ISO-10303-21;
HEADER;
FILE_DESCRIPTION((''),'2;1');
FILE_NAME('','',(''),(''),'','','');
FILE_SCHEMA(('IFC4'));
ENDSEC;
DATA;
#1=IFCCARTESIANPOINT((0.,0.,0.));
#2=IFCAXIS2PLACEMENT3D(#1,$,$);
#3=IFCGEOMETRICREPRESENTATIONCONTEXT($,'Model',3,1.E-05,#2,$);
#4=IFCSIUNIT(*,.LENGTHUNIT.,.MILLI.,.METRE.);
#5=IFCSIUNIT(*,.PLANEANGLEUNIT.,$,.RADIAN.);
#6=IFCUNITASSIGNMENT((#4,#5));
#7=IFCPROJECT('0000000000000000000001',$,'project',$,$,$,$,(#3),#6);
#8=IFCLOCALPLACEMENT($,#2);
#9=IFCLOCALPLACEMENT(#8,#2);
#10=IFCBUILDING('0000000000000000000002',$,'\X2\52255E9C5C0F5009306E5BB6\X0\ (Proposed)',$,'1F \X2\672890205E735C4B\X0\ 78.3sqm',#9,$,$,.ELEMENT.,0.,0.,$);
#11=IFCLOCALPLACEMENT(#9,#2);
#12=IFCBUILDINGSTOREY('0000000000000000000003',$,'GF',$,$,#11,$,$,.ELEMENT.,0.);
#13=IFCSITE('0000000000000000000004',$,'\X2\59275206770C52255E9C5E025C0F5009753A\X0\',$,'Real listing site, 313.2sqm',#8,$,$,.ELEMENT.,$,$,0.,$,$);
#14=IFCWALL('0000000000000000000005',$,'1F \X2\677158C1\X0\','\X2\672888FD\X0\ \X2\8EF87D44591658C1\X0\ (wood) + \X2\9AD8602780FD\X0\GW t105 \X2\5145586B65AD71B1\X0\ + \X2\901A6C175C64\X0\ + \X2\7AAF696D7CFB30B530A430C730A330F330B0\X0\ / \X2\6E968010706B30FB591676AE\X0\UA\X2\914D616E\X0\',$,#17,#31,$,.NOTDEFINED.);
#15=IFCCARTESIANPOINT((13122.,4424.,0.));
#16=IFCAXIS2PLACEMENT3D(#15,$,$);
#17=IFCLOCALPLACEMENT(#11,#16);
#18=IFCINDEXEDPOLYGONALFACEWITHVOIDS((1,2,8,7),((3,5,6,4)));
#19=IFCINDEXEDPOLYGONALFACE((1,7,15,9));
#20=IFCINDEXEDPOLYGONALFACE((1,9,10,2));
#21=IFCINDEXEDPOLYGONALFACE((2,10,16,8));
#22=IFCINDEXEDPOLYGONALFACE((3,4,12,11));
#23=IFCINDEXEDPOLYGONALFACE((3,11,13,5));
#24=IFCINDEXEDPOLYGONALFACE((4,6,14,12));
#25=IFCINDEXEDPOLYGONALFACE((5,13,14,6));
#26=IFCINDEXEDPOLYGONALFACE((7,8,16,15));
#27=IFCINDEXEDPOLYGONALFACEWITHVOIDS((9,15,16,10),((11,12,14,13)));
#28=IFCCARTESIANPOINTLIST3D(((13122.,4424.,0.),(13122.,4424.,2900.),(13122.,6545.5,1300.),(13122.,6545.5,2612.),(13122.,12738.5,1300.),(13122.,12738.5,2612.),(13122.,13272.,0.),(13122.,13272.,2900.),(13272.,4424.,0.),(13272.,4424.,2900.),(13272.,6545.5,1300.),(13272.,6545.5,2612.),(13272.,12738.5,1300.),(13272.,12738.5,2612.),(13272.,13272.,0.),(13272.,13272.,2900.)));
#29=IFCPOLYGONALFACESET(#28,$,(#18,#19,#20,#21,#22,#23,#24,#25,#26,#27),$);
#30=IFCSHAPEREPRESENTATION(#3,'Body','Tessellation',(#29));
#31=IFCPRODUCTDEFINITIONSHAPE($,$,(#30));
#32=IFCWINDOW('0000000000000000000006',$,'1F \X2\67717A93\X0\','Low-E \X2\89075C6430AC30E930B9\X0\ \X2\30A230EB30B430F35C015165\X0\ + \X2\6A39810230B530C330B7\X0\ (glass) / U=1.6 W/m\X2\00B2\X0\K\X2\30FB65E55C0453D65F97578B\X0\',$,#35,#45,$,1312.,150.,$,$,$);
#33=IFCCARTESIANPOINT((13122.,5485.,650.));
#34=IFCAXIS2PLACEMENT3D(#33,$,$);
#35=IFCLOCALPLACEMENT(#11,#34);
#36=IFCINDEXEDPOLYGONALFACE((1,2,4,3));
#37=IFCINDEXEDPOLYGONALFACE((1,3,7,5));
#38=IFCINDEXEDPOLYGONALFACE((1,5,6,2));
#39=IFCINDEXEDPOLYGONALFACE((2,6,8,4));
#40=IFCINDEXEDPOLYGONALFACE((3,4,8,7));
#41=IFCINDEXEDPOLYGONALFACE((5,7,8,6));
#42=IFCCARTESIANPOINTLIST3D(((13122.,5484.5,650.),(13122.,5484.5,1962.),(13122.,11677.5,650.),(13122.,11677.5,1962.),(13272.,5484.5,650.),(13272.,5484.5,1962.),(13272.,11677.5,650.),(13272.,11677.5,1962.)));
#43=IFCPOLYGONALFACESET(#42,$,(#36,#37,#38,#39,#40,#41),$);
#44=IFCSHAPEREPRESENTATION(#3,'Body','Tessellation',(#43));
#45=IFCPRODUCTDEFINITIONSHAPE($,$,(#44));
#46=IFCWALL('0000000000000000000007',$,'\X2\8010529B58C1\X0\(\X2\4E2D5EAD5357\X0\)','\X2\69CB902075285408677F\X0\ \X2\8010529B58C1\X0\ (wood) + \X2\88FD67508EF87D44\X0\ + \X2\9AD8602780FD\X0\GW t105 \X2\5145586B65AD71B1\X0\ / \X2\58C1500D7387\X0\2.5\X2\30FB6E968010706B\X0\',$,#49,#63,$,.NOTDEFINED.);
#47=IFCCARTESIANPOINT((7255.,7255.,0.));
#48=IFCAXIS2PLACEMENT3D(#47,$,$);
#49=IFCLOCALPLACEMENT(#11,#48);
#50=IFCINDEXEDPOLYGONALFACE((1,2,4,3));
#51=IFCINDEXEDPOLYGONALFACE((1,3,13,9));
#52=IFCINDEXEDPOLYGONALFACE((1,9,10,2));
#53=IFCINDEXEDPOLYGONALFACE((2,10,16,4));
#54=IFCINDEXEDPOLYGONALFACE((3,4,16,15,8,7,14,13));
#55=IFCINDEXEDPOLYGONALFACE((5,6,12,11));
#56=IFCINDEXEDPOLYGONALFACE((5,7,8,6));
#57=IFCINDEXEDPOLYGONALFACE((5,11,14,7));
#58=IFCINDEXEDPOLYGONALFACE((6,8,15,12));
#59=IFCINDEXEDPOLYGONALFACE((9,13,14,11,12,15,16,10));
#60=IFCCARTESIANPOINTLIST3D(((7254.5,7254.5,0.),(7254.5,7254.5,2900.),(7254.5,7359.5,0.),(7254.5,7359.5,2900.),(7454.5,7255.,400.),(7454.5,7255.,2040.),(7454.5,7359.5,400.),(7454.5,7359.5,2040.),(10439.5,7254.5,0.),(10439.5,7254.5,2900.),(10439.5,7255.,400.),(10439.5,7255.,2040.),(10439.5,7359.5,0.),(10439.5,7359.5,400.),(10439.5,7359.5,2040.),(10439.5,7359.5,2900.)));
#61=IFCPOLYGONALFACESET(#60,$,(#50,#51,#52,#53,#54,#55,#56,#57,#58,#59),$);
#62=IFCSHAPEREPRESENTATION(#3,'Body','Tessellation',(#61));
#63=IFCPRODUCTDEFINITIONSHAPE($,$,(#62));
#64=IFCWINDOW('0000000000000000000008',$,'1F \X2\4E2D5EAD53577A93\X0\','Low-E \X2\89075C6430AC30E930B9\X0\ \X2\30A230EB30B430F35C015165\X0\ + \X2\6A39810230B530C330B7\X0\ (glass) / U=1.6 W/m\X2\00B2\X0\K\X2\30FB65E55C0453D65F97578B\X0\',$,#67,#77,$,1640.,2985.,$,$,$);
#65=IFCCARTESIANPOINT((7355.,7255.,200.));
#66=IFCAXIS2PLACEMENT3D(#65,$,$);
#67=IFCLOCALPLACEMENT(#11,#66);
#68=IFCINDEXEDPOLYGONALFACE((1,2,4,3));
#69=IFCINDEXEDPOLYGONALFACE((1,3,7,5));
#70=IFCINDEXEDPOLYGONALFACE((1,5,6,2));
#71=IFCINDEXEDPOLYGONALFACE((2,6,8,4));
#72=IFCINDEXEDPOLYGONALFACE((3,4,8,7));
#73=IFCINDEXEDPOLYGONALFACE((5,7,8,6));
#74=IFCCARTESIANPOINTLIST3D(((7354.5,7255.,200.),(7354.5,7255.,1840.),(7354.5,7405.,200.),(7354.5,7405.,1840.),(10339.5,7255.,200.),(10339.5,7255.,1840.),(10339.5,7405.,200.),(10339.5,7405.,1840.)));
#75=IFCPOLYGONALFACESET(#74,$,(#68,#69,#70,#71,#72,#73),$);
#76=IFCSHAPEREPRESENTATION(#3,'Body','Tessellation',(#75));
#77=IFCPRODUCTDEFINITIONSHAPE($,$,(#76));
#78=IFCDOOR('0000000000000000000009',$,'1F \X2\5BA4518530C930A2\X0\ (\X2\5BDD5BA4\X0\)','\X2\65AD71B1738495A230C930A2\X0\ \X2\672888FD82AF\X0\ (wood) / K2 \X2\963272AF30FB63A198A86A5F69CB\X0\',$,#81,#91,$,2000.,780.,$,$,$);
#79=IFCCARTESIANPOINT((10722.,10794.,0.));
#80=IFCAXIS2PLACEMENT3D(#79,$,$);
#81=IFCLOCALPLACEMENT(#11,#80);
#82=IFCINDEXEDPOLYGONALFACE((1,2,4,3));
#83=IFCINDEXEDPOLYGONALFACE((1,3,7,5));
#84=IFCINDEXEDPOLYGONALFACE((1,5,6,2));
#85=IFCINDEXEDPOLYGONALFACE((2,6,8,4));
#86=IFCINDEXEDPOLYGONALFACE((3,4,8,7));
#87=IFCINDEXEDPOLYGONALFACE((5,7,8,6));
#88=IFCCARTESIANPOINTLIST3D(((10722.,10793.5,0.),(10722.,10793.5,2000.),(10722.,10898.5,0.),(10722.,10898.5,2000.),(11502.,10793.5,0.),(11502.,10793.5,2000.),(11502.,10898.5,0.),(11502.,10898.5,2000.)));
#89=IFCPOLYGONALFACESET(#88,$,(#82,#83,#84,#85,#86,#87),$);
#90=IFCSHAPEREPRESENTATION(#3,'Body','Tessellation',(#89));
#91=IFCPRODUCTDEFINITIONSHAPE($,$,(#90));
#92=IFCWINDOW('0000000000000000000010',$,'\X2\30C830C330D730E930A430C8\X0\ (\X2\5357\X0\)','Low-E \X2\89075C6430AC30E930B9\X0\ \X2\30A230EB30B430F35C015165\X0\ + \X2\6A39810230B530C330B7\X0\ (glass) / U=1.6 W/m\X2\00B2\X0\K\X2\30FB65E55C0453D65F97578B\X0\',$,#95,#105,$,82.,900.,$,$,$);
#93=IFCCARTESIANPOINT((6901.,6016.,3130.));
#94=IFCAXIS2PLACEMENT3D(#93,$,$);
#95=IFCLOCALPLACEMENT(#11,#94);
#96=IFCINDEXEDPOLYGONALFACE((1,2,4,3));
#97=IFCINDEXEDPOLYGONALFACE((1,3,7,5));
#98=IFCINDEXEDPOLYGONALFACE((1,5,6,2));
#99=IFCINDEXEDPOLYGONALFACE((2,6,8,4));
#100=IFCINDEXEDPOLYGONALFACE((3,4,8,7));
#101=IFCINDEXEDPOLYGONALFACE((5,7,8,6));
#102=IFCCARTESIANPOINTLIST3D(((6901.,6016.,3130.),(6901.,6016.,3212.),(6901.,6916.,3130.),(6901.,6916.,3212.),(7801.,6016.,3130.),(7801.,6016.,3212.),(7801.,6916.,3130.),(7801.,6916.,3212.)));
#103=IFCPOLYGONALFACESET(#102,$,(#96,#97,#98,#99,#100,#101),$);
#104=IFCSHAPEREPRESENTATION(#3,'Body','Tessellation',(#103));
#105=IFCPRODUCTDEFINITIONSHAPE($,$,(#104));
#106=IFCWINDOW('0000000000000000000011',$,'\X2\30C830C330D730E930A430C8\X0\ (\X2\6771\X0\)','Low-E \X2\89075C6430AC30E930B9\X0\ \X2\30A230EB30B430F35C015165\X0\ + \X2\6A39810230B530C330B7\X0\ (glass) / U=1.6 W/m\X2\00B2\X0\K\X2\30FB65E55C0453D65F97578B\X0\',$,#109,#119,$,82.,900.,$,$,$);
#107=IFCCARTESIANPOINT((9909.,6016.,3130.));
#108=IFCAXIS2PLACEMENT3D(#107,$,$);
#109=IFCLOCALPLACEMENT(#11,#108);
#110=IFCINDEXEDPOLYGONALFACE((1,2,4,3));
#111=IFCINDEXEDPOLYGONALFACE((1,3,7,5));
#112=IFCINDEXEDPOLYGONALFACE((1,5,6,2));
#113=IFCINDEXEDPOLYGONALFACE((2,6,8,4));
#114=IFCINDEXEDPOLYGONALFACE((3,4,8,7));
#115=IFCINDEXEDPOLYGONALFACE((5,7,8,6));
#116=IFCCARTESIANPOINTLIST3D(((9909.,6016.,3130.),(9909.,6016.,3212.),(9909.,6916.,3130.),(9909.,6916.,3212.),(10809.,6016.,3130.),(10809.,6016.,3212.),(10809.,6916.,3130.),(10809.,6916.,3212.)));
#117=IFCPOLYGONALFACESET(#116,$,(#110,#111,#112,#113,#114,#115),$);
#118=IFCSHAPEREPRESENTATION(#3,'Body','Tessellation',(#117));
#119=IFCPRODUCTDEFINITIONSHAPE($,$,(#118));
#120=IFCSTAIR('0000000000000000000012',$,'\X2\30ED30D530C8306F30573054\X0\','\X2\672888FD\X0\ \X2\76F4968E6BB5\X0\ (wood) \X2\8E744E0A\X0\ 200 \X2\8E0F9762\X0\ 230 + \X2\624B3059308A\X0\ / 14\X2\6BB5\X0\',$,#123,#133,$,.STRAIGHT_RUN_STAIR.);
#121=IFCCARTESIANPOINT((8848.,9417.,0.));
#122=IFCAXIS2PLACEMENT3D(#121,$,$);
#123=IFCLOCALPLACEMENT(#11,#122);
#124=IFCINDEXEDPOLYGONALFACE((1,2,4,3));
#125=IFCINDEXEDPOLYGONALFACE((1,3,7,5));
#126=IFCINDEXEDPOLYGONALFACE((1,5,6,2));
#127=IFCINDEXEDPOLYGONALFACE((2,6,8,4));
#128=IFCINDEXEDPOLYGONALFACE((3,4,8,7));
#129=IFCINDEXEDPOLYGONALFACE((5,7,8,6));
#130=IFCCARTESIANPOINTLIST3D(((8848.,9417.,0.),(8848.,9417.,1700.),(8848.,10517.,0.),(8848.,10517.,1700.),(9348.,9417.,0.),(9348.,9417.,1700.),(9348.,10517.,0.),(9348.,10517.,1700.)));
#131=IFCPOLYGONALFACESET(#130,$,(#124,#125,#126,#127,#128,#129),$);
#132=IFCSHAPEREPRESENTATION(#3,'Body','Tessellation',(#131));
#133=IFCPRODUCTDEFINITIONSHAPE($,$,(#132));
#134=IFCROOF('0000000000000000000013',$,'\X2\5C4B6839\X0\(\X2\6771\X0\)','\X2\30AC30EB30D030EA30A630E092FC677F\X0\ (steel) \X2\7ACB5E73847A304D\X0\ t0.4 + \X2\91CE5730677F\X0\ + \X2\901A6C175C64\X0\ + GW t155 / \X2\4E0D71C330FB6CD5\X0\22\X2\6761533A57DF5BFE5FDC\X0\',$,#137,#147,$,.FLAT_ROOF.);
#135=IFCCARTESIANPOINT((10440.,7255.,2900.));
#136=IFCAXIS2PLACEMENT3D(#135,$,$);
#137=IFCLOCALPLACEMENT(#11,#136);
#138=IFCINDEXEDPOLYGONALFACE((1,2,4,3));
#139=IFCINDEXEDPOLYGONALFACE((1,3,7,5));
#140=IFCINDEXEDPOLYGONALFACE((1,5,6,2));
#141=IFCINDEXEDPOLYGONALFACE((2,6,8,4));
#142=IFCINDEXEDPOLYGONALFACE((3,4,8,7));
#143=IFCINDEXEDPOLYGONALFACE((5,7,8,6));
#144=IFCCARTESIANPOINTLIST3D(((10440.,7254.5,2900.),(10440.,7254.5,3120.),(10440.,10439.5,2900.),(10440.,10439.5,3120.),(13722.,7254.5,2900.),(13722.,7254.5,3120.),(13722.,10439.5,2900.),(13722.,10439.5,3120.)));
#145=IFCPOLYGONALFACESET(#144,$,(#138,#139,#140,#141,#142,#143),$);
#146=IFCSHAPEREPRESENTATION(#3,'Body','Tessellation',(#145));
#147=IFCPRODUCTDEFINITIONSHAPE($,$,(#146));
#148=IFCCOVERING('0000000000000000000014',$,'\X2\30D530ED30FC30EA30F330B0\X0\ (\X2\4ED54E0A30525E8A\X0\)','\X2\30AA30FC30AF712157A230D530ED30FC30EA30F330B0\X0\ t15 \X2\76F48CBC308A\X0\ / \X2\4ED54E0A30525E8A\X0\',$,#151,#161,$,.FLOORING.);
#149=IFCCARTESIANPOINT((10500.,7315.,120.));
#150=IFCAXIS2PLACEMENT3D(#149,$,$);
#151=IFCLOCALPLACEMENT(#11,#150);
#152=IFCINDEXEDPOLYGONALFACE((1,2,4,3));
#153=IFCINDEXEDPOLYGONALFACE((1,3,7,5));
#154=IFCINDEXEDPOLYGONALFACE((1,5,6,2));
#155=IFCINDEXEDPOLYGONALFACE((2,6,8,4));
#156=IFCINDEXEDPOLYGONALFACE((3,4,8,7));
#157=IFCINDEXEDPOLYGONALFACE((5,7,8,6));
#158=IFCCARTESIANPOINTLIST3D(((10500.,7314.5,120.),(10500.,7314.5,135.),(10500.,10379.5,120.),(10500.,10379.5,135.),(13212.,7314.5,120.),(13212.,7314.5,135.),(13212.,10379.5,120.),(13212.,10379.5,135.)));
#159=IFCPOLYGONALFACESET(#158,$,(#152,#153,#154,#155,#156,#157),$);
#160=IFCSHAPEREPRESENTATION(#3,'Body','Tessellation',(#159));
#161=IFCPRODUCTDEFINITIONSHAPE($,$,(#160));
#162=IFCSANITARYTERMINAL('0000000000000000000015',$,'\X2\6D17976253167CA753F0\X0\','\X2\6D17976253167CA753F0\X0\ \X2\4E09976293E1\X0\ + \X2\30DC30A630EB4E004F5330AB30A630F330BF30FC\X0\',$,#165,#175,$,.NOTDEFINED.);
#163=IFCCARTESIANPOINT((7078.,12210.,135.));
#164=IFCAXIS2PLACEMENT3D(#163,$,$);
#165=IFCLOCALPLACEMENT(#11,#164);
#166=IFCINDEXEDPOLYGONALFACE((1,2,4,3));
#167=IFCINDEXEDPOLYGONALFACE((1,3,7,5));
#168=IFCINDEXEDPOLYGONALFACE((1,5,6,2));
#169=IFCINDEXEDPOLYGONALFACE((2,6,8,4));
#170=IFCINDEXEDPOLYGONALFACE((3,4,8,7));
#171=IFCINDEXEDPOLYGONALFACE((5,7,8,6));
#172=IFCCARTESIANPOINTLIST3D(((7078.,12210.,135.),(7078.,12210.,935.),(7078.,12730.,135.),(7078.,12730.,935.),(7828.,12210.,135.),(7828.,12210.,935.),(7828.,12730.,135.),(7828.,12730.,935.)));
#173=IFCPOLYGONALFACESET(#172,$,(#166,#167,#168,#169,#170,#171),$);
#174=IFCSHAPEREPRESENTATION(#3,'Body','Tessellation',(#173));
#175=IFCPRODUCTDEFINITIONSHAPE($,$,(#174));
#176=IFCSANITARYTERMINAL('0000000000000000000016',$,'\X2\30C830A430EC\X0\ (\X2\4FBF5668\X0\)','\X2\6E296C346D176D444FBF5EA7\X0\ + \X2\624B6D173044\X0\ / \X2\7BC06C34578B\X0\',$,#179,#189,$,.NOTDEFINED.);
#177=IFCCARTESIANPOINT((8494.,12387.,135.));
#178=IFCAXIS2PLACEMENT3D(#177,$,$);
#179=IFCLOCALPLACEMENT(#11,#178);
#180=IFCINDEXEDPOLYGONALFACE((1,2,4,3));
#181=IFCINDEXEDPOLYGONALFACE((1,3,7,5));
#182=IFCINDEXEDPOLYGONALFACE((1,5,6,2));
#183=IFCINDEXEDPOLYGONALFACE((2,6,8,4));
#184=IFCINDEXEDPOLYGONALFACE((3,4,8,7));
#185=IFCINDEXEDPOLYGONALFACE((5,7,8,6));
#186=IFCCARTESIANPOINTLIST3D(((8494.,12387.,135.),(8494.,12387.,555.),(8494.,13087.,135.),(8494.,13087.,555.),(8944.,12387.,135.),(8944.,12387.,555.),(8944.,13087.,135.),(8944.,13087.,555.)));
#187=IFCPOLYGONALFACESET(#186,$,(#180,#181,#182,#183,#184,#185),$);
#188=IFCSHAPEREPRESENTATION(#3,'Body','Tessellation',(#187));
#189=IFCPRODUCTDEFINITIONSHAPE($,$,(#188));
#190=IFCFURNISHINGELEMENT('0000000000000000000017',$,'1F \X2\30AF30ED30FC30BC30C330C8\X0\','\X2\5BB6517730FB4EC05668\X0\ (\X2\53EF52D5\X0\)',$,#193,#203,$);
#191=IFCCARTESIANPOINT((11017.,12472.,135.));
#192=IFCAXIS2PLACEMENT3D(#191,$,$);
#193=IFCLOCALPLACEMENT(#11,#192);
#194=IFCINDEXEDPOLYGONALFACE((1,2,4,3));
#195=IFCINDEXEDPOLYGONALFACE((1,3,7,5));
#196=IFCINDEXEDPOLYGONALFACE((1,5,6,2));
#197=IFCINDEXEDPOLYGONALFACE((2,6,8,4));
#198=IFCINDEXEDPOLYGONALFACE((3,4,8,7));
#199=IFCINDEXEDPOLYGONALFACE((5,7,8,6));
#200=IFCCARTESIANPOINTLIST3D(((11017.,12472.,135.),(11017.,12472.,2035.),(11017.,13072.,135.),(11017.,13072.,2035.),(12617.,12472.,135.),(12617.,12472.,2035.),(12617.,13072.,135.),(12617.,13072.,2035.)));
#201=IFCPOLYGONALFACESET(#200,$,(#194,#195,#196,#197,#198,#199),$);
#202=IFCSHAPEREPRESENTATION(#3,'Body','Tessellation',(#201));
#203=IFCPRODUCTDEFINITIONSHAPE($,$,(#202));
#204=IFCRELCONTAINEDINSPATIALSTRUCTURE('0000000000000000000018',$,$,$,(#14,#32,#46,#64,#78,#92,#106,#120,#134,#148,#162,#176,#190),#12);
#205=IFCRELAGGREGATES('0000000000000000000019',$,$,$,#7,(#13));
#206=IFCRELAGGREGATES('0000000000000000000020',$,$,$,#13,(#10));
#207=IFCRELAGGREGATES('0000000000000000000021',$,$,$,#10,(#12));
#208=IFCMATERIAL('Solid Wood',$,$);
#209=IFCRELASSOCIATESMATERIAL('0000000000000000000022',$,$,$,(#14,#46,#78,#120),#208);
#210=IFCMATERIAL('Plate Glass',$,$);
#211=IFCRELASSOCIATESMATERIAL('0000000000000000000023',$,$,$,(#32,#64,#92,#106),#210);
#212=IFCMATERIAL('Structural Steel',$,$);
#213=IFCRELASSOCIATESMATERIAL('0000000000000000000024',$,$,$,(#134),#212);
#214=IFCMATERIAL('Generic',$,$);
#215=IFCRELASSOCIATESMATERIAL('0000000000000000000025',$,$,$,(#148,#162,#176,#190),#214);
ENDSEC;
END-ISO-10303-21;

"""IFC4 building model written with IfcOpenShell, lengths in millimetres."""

from ifc_helpers import new_model, si_unit, frame, frame_2d, origin, place, context, project, spatial, rectangle, extrude, material, element, fill, save


model = new_model("IFC4")

# Units and contexts
model_context = context("Model", 3, precision=1e-05, world=origin())
ifc_project = project(units=[si_unit("LENGTHUNIT", "METRE", prefix="MILLI"), si_unit("PLANEANGLEUNIT", "RADIAN")], contexts=[model_context])

# Site, building, storey
site_placement = place(None, origin())
site = spatial("IfcSite", under=ifc_project, at=site_placement, Name="大分県別府市小倉町", ObjectType="Real listing site, 313.2sqm", CompositionType="ELEMENT", RefElevation=0.0)
building_placement = place(site_placement, origin())
building = spatial("IfcBuilding", under=site, at=building_placement, Name="別府小倉の家 (Proposed)", ObjectType="1F 木造平屋 78.3sqm", CompositionType="ELEMENT", ElevationOfRefHeight=0.0, ElevationOfTerrain=0.0)
storey_placement = place(building_placement, origin())
storey = spatial("IfcBuildingStorey", under=building, at=storey_placement, Name="GF", CompositionType="ELEMENT", Elevation=0.0)

# Shared definitions
ifc_material_1 = material(Name="Solid Wood")

# Walls, openings, windows
wall_1_placement = place(storey_placement, frame((13122.0, 4424.0, 0.0)))
wall_1 = element("IfcWall", 1, at=wall_1_placement, inside=storey, material=ifc_material_1, Name="1F 東壁", Description="木製 軸組外壁 (wood) + 高性能GW t105 充填断熱 + 通気層 + 窯業系サイディング / 準耐火・外皮UA配慮", PredefinedType="NOTDEFINED", context=model_context, shape_type="SweptSolid", body=[
    extrude(rectangle(XDim=150.0, YDim=8848.0, at=frame_2d((75.0, 4424.0))), frame((13122.0, 4424.0, 0.0)), (0.0, 0.0, 1.0), 2900.0),
])
opening_1_placement = place(storey_placement, frame((13122.0, 5485.0, 650.0)))
opening_1 = element("IfcOpeningElement", 2, at=opening_1_placement, cuts=wall_1, PredefinedType="NOTDEFINED", context=model_context, shape_type="SweptSolid", body=[
    extrude(rectangle(XDim=150.0, YDim=6193.0, at=frame_2d((75.0, 3096.0))), frame((13122.0, 5485.0, 650.0)), (0.0, 0.0, 1.0), 1312.0),
])
ifc_material_2 = material(Name="Plate Glass")
window_1_placement = place(storey_placement, frame((13122.0, 5485.0, 650.0)))
window_1 = element("IfcWindow", 3, at=window_1_placement, inside=storey, material=ifc_material_2, Name="1F 東窓", Description="Low-E 複層ガラス アルゴン封入 + 樹脂サッシ (glass) / U=1.6 W/m²K・日射取得型", OverallHeight=1312.0, OverallWidth=150.0, context=model_context, shape_type="SweptSolid", body=[
    extrude(rectangle(XDim=150.0, YDim=6193.0, at=frame_2d((75.0, 3096.0))), frame((13122.0, 5485.0, 650.0)), (0.0, 0.0, 1.0), 1312.0),
])
fill(opening_1, window_1)
wall_2_placement = place(storey_placement, frame((7255.0, 7255.0, 0.0)))
wall_2 = element("IfcWall", 4, at=wall_2_placement, inside=storey, material=ifc_material_1, Name="耐力壁(中庭南)", Description="構造用合板 耐力壁 (wood) + 製材軸組 + 高性能GW t105 充填断熱 / 壁倍率2.5・準耐火", PredefinedType="NOTDEFINED", context=model_context, shape_type="SweptSolid", body=[
    extrude(rectangle(XDim=3185.0, YDim=105.0, at=frame_2d((1592.0, 52.0))), frame((7255.0, 7255.0, 0.0)), (0.0, 0.0, 1.0), 2900.0),
])
opening_2_placement = place(storey_placement, frame((7355.0, 7255.0, 200.0)))
opening_2 = element("IfcOpeningElement", 5, at=opening_2_placement, cuts=wall_2, PredefinedType="NOTDEFINED", context=model_context, shape_type="SweptSolid", body=[
    extrude(rectangle(XDim=2985.0, YDim=150.0, at=frame_2d((1492.0, 75.0))), frame((7355.0, 7255.0, 200.0)), (0.0, 0.0, 1.0), 1640.0),
])
window_2_placement = place(storey_placement, frame((7355.0, 7255.0, 200.0)))
window_2 = element("IfcWindow", 6, at=window_2_placement, inside=storey, material=ifc_material_2, Name="1F 中庭南窓", Description="Low-E 複層ガラス アルゴン封入 + 樹脂サッシ (glass) / U=1.6 W/m²K・日射取得型", OverallHeight=1640.0, OverallWidth=2985.0, context=model_context, shape_type="SweptSolid", body=[
    extrude(rectangle(XDim=2985.0, YDim=150.0, at=frame_2d((1492.0, 75.0))), frame((7355.0, 7255.0, 200.0)), (0.0, 0.0, 1.0), 1640.0),
])
fill(opening_2, window_2)

# Door
door_placement = place(storey_placement, frame((10722.0, 10794.0, 0.0)))
element("IfcDoor", 7, at=door_placement, inside=storey, material=ifc_material_1, Name="1F 室内ドア (寝室)", Description="断熱玄関ドア 木製芯 (wood) / K2 防犯・採風機構", OverallHeight=2000.0, OverallWidth=780.0, context=model_context, shape_type="SweptSolid", body=[
    extrude(rectangle(XDim=780.0, YDim=105.0, at=frame_2d((390.0, 52.0))), frame((10722.0, 10794.0, 0.0)), (0.0, 0.0, 1.0), 2000.0),
])

# Windows
window_3_placement = place(storey_placement, frame((6901.0, 6016.0, 3130.0)))
element("IfcWindow", 8, at=window_3_placement, inside=storey, material=ifc_material_2, Name="トップライト (南)", Description="Low-E 複層ガラス アルゴン封入 + 樹脂サッシ (glass) / U=1.6 W/m²K・日射取得型", OverallHeight=82.0, OverallWidth=900.0, context=model_context, shape_type="SweptSolid", body=[
    extrude(rectangle(XDim=900.0, YDim=900.0, at=frame_2d((450.0, 450.0))), frame((6901.0, 6016.0, 3130.0)), (0.0, 0.0, 1.0), 82.0),
])
window_4_placement = place(storey_placement, frame((9909.0, 6016.0, 3130.0)))
element("IfcWindow", 9, at=window_4_placement, inside=storey, material=ifc_material_2, Name="トップライト (東)", Description="Low-E 複層ガラス アルゴン封入 + 樹脂サッシ (glass) / U=1.6 W/m²K・日射取得型", OverallHeight=82.0, OverallWidth=900.0, context=model_context, shape_type="SweptSolid", body=[
    extrude(rectangle(XDim=900.0, YDim=900.0, at=frame_2d((450.0, 450.0))), frame((9909.0, 6016.0, 3130.0)), (0.0, 0.0, 1.0), 82.0),
])

# Stair
stair_placement = place(storey_placement, frame((8848.0, 9417.0, 0.0)))
element("IfcStair", 10, at=stair_placement, inside=storey, material=ifc_material_1, Name="ロフトはしご", Description="木製 直階段 (wood) 蹴上 200 踏面 230 + 手すり / 14段", PredefinedType="STRAIGHT_RUN_STAIR", context=model_context, shape_type="SweptSolid", body=[
    extrude(rectangle(XDim=500.0, YDim=1100.0, at=frame_2d((250.0, 550.0))), frame((8848.0, 9417.0, 0.0)), (0.0, 0.0, 1.0), 1700.0),
])

# Roof
ifc_material_3 = material(Name="Structural Steel")
roof_placement = place(storey_placement, frame((10440.0, 7255.0, 2900.0)))
element("IfcRoof", 11, at=roof_placement, inside=storey, material=ifc_material_3, Name="屋根(東)", Description="ガルバリウム鋼板 (steel) 立平葺き t0.4 + 野地板 + 通気層 + GW t155 / 不燃・法22条区域対応", PredefinedType="FLAT_ROOF", context=model_context, shape_type="SweptSolid", body=[
    extrude(rectangle(XDim=3282.0, YDim=3185.0, at=frame_2d((1641.0, 1592.0))), frame((10440.0, 7255.0, 2900.0)), (0.0, 0.0, 1.0), 220.0),
])

# Covering
ifc_material_4 = material(Name="Generic")
covering_placement = place(storey_placement, frame((10500.0, 7315.0, 120.0)))
element("IfcCovering", 12, at=covering_placement, inside=storey, material=ifc_material_4, Name="フローリング (仕上げ床)", Description="オーク無垢フローリング t15 直貼り / 仕上げ床", PredefinedType="FLOORING", context=model_context, shape_type="SweptSolid", body=[
    extrude(rectangle(XDim=2712.0, YDim=3065.0, at=frame_2d((1356.0, 1532.0))), frame((10500.0, 7315.0, 120.0)), (0.0, 0.0, 1.0), 15.0),
])

# Sanitary terminals
sanitary_terminal_1_placement = place(storey_placement, frame((7078.0, 12210.0, 135.0)))
element("IfcSanitaryTerminal", 13, at=sanitary_terminal_1_placement, inside=storey, material=ifc_material_4, Name="洗面化粧台", Description="洗面化粧台 三面鏡 + ボウル一体カウンター", PredefinedType="NOTDEFINED", context=model_context, shape_type="SweptSolid", body=[
    extrude(rectangle(XDim=750.0, YDim=520.0, at=frame_2d((375.0, 260.0))), frame((7078.0, 12210.0, 135.0)), (0.0, 0.0, 1.0), 800.0),
])
sanitary_terminal_2_placement = place(storey_placement, frame((8494.0, 12387.0, 135.0)))
element("IfcSanitaryTerminal", 14, at=sanitary_terminal_2_placement, inside=storey, material=ifc_material_4, Name="トイレ (便器)", Description="温水洗浄便座 + 手洗い / 節水型", PredefinedType="NOTDEFINED", context=model_context, shape_type="SweptSolid", body=[
    extrude(rectangle(XDim=450.0, YDim=700.0, at=frame_2d((225.0, 350.0))), frame((8494.0, 12387.0, 135.0)), (0.0, 0.0, 1.0), 420.0),
])

# Furnishing element
furnishing_1_placement = place(storey_placement, frame((11017.0, 12472.0, 135.0)))
element("IfcFurnishingElement", 15, at=furnishing_1_placement, inside=storey, material=ifc_material_4, Name="1F クローゼット", Description="家具・什器 (可動)", context=model_context, shape_type="SweptSolid", body=[
    extrude(rectangle(XDim=1600.0, YDim=600.0, at=frame_2d((800.0, 300.0))), frame((11017.0, 12472.0, 135.0)), (0.0, 0.0, 1.0), 1900.0),
])

save(model, "model.ifc")
